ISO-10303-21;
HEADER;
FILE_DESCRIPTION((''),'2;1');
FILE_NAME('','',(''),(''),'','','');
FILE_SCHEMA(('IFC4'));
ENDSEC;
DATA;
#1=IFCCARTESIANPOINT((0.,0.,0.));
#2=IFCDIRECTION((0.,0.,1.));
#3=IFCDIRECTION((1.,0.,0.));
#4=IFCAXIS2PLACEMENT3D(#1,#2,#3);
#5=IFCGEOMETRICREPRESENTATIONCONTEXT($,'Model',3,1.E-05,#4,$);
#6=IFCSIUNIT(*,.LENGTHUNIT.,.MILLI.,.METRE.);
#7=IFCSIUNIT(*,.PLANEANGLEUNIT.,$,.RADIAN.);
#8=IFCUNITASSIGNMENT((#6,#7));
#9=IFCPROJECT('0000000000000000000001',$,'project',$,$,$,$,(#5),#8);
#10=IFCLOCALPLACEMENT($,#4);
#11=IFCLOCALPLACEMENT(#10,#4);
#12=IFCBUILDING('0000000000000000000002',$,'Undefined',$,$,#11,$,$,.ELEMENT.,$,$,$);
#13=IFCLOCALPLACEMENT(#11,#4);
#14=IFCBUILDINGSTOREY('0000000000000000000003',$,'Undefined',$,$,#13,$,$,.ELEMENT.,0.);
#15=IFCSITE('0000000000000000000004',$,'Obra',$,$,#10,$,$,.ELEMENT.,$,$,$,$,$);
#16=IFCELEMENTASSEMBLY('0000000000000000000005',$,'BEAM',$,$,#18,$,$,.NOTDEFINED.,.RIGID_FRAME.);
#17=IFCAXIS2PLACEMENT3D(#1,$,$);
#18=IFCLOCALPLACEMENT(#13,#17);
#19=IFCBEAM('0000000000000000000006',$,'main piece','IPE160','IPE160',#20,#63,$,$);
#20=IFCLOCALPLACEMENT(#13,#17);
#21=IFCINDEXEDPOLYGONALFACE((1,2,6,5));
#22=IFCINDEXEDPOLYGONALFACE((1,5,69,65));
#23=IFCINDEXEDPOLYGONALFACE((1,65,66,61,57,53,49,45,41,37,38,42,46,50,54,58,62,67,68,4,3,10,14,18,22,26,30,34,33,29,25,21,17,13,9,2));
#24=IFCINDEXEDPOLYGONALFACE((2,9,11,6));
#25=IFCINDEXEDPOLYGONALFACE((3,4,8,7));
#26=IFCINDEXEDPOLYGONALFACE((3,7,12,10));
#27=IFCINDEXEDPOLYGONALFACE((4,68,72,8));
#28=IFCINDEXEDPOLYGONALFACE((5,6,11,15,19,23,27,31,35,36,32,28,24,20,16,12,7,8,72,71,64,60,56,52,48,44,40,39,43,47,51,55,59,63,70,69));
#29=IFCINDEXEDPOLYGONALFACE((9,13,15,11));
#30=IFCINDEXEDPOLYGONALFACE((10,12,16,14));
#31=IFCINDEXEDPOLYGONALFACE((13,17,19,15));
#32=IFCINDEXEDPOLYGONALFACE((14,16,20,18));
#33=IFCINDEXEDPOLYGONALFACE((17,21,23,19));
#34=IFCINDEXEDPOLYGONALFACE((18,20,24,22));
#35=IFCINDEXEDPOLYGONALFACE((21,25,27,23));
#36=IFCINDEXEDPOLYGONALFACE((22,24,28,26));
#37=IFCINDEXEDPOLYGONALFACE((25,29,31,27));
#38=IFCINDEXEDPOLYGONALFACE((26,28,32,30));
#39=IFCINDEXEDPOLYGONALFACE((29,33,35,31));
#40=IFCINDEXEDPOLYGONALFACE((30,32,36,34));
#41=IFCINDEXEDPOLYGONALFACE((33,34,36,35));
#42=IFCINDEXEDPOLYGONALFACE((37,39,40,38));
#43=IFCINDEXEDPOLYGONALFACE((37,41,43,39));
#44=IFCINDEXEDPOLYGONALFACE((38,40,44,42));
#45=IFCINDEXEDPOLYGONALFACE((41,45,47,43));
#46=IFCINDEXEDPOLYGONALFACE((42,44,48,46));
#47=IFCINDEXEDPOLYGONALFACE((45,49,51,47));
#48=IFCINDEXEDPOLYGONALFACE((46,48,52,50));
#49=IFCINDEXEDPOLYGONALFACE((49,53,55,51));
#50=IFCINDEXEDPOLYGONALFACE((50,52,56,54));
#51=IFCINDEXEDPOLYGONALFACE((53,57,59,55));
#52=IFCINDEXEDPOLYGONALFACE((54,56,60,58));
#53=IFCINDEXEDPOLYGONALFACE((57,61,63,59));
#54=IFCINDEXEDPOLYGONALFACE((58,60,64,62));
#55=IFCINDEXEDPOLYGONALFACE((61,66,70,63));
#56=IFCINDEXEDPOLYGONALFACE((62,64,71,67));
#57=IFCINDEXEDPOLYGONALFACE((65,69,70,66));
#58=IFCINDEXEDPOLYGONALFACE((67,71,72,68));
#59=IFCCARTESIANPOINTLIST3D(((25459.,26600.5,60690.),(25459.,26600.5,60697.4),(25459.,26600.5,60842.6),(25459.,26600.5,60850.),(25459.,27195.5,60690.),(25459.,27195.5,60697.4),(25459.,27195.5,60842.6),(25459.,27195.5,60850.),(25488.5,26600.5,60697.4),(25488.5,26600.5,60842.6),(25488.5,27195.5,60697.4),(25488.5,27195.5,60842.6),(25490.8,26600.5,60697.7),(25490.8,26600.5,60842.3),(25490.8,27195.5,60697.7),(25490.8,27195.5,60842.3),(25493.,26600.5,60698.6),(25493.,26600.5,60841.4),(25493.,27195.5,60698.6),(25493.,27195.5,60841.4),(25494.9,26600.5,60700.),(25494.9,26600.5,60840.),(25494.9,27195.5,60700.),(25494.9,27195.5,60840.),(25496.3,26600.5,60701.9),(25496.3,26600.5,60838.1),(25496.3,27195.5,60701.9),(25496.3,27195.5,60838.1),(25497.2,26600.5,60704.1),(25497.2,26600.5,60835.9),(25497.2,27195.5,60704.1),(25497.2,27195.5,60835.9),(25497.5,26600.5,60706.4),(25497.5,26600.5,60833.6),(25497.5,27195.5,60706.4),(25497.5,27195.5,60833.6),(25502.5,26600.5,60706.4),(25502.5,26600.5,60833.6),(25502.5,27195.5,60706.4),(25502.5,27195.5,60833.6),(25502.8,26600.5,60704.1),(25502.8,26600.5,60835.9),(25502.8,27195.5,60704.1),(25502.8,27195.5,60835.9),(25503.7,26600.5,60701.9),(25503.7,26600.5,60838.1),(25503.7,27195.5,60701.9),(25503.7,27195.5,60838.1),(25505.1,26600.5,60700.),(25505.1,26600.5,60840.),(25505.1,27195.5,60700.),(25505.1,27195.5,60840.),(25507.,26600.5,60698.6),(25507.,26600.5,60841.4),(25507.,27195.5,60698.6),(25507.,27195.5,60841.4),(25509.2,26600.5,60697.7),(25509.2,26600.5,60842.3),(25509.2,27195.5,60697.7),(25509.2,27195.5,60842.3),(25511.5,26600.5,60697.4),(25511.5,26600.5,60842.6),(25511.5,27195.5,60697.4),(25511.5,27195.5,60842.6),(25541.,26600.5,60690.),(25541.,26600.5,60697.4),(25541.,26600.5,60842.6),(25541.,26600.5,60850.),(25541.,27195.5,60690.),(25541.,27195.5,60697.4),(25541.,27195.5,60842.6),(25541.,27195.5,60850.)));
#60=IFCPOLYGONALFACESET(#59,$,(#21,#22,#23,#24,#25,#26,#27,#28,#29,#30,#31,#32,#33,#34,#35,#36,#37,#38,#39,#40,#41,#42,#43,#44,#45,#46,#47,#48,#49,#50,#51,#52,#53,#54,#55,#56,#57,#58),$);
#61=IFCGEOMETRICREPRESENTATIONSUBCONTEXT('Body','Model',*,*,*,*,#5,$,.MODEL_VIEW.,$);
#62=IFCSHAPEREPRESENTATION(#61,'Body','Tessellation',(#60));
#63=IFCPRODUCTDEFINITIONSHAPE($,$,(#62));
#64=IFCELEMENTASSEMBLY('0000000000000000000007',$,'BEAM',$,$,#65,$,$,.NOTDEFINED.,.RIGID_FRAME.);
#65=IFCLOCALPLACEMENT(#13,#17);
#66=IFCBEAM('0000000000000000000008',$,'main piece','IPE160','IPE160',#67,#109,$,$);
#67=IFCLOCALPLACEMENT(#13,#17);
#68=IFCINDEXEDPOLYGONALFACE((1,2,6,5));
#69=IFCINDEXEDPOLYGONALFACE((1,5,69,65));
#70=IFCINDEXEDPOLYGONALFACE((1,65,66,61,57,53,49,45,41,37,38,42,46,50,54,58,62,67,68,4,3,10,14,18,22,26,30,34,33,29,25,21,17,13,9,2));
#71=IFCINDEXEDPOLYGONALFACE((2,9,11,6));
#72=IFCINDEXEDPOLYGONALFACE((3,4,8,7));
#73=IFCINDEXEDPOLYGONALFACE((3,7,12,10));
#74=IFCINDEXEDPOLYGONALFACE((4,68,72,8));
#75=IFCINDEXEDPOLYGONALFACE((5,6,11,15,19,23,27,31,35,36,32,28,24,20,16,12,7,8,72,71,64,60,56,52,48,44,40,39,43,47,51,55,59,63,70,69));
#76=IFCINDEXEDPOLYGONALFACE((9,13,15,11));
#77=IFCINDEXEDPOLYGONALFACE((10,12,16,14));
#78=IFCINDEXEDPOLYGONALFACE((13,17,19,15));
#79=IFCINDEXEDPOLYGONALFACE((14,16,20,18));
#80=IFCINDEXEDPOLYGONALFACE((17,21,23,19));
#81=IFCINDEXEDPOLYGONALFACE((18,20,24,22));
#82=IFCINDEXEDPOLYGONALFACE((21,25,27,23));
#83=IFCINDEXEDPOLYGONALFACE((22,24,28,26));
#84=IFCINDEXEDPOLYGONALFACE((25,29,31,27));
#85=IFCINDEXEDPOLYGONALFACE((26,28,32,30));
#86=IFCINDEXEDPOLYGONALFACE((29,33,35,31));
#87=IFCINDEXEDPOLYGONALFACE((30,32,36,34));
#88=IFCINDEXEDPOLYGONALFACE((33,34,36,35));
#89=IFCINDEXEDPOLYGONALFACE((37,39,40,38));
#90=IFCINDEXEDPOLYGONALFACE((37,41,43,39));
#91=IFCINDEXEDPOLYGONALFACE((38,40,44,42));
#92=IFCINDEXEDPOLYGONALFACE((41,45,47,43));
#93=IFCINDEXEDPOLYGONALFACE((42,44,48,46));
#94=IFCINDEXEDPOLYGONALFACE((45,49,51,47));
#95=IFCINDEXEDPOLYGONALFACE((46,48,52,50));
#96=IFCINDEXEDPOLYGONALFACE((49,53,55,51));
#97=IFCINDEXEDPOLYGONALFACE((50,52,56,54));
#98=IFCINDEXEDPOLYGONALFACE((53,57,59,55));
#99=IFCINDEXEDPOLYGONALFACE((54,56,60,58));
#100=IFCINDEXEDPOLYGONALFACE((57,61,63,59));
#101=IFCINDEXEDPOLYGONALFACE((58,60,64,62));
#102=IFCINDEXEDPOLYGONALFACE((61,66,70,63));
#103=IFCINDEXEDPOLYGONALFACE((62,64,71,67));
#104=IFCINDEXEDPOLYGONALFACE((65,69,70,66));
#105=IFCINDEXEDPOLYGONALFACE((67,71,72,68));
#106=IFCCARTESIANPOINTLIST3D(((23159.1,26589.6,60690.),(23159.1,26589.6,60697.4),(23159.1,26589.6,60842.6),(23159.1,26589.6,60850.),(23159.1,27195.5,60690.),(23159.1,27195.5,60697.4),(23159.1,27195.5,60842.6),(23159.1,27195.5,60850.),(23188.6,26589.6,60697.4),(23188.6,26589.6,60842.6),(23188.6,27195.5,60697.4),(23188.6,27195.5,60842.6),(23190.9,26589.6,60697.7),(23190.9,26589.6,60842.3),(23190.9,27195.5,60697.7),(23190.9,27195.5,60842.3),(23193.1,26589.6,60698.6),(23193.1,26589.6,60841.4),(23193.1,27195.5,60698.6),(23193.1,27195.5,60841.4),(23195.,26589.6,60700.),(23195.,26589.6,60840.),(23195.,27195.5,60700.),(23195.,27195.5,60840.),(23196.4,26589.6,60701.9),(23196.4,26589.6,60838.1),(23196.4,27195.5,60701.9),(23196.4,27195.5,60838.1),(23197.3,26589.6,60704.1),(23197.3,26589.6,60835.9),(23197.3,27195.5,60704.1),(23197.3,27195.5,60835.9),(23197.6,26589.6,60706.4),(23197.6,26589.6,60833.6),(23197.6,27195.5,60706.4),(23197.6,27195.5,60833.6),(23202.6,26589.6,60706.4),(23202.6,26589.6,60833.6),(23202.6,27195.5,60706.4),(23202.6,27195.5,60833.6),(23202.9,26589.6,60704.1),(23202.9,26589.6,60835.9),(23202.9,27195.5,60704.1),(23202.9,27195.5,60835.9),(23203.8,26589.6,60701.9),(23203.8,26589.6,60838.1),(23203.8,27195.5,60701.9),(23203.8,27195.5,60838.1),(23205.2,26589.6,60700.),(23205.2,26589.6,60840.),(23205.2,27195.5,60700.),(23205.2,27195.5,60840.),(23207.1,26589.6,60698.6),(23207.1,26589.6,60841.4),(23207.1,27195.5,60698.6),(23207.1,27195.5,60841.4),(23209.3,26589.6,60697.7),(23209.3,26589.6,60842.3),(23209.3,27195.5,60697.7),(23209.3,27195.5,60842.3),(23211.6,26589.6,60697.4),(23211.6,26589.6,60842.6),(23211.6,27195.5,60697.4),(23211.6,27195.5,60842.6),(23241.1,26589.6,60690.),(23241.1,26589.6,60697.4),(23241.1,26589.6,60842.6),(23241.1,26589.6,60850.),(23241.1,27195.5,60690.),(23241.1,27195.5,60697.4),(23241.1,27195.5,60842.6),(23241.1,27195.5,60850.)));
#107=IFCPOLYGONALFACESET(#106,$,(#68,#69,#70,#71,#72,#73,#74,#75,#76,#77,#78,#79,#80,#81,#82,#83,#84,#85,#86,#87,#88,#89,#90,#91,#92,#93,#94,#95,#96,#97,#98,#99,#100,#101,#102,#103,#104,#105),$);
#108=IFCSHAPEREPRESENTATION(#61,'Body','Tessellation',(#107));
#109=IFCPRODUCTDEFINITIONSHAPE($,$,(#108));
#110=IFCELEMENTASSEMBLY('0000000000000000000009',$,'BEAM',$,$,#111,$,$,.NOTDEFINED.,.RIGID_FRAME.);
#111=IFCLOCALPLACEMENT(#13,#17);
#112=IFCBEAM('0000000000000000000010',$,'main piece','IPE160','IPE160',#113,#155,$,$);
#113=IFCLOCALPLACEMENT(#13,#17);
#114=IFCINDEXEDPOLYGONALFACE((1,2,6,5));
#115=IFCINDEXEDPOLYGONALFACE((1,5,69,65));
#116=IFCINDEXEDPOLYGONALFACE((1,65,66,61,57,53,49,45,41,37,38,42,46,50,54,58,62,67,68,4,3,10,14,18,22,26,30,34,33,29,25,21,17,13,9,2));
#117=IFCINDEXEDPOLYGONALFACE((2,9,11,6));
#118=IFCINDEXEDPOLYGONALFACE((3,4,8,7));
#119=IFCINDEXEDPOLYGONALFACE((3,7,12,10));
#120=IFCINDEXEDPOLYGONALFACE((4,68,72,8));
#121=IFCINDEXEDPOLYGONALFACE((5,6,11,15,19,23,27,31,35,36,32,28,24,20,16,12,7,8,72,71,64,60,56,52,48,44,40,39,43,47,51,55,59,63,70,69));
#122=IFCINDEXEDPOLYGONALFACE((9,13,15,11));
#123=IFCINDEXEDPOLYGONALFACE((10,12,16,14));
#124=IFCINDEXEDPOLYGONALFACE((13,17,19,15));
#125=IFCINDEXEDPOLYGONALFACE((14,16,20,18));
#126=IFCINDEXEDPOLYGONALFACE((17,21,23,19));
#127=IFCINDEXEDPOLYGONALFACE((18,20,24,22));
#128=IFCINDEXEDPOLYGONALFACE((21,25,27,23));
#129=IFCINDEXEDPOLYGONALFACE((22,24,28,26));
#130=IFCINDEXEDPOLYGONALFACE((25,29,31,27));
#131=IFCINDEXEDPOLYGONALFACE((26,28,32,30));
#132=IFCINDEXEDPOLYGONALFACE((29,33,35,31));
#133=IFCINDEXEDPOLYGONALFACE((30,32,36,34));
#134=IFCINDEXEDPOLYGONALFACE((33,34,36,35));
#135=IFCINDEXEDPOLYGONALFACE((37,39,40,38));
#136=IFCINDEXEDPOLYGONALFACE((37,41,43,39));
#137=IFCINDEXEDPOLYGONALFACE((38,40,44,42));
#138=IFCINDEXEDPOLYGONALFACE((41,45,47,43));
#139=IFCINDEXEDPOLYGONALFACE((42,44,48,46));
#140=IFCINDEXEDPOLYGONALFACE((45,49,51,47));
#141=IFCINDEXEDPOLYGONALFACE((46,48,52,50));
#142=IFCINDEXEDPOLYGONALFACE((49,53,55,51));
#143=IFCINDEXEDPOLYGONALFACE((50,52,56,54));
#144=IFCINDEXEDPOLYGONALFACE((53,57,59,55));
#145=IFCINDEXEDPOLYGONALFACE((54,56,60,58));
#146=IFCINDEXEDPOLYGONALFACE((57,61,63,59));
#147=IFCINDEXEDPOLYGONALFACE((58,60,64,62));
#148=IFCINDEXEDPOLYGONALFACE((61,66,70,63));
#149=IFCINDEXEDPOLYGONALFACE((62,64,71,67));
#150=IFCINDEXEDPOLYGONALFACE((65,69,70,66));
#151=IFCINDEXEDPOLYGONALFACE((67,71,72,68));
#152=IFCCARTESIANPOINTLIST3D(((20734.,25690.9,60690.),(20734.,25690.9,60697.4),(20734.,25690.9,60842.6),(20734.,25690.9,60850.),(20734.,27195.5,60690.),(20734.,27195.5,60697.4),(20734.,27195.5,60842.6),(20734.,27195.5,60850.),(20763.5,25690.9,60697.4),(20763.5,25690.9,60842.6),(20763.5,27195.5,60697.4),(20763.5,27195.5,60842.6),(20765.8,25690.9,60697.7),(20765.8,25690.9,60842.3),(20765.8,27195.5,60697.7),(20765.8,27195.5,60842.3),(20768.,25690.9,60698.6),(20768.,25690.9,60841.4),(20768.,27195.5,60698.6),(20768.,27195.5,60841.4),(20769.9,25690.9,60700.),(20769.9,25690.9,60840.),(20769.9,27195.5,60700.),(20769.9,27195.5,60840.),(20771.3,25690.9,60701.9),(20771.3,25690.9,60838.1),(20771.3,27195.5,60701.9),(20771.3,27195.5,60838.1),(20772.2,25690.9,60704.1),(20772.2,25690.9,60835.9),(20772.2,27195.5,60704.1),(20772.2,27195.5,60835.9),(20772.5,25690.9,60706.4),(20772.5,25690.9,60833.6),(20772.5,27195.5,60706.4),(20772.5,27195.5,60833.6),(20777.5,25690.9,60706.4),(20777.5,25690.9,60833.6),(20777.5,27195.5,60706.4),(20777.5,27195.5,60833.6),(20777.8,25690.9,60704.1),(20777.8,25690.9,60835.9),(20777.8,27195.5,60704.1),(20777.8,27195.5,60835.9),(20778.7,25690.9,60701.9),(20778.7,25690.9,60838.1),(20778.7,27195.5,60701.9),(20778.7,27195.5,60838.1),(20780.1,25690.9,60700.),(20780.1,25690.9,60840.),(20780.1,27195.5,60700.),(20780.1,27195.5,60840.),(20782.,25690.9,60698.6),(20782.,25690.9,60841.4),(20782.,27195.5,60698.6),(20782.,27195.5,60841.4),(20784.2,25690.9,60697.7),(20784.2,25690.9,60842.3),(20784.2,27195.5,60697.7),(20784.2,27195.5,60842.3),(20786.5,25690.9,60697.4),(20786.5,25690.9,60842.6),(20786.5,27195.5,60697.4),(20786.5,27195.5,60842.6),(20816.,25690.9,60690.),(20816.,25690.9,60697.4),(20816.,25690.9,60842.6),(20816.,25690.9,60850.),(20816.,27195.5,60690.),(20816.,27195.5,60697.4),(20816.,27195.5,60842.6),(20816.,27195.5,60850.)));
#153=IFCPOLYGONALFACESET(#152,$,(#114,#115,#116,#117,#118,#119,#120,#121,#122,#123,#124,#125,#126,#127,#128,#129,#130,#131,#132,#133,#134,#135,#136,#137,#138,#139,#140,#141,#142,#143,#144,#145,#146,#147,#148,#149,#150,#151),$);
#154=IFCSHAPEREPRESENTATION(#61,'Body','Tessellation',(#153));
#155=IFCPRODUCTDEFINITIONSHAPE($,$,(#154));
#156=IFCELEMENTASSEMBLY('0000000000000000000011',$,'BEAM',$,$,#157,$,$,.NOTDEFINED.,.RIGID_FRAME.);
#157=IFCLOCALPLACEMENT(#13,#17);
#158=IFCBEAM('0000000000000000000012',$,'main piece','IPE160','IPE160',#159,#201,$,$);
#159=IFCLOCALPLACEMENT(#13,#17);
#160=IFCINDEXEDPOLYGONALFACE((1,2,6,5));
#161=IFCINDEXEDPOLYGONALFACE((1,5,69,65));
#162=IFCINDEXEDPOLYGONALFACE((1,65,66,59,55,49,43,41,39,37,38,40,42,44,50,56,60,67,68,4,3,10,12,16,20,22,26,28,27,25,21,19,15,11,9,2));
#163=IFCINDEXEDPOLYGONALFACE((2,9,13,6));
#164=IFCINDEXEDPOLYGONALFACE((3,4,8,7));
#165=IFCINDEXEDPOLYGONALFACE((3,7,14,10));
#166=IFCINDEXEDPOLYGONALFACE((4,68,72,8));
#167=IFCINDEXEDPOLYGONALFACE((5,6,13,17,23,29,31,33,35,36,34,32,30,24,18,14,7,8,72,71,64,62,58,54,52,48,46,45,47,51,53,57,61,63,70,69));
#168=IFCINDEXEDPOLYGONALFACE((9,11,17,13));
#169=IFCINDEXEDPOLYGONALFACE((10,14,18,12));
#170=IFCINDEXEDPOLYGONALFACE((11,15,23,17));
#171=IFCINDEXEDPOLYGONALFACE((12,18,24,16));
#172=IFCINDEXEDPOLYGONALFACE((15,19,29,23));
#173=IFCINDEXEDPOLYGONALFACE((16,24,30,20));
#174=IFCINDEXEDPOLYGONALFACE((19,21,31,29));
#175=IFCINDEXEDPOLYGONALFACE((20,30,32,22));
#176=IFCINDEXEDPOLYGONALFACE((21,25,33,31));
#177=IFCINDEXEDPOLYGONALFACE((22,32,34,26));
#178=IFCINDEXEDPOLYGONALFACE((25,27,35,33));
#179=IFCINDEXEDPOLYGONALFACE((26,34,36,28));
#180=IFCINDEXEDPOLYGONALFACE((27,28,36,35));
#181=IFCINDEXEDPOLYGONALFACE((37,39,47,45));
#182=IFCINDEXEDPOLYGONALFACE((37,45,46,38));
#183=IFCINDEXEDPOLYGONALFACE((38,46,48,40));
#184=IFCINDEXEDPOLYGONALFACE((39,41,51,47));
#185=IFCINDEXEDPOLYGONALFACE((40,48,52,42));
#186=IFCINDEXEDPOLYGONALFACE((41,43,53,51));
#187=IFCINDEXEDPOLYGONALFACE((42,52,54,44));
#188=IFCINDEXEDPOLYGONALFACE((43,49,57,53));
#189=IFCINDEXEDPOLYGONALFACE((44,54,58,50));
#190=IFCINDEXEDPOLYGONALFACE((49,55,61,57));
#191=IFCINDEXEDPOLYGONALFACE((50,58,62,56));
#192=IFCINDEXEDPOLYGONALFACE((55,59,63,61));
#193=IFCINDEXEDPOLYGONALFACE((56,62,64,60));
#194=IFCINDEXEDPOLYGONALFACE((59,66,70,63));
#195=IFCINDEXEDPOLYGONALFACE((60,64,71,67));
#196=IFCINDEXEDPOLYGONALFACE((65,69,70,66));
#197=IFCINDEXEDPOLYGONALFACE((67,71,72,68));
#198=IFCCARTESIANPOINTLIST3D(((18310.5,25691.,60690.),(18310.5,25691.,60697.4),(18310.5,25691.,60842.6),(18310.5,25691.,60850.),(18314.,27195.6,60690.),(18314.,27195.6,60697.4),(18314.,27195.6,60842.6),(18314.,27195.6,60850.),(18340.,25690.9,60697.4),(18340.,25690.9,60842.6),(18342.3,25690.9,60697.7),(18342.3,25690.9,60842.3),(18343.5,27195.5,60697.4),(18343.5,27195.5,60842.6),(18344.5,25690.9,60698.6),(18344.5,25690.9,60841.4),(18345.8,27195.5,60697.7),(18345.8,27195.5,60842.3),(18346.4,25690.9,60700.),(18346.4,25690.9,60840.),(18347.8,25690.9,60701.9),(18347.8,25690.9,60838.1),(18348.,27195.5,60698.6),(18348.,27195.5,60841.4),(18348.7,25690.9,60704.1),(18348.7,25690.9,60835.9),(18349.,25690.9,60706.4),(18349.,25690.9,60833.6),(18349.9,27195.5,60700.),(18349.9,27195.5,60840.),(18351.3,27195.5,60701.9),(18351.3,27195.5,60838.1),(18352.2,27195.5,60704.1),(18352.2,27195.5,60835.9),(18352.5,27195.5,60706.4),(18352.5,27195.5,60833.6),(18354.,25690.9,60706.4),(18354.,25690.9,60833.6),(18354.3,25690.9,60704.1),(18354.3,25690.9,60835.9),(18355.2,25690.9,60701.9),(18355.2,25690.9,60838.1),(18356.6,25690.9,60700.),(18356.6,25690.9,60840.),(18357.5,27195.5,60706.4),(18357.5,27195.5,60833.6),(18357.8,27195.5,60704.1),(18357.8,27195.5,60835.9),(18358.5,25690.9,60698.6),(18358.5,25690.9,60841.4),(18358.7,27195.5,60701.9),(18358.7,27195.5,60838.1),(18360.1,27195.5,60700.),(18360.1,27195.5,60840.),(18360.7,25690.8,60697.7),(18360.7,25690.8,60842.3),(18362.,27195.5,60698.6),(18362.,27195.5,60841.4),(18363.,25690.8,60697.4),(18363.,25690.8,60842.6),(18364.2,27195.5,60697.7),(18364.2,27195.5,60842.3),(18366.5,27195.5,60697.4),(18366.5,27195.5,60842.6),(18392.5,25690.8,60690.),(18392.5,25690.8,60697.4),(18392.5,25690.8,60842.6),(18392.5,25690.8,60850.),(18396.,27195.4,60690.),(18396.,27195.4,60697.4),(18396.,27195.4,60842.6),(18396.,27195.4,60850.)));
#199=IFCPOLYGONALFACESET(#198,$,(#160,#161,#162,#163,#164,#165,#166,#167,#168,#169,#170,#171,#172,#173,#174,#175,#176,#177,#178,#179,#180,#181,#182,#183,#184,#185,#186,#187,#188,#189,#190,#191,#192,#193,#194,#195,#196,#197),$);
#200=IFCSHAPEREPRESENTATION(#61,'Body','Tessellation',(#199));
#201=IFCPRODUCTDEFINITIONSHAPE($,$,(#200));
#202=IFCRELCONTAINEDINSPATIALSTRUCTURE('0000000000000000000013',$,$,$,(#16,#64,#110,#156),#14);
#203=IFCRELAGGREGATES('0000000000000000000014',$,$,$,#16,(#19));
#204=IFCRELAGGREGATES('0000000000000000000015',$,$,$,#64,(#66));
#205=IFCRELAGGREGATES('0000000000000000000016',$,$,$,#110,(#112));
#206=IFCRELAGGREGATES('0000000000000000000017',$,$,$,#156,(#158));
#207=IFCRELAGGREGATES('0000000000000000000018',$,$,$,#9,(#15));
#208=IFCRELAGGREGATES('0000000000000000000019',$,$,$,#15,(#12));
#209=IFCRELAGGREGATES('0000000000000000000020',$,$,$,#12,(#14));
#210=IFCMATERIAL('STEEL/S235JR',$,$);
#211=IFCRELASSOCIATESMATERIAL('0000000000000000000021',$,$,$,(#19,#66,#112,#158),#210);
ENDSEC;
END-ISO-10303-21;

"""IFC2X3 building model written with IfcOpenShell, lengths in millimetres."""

from ifc_helpers import new_model, si_unit, frame, origin_with_axes, origin_2d_with_axis, place, context, subcontext, project, spatial, i_section, extrude, material, element, aggregate, save


model = new_model("IFC2X3")

# Units and contexts
model_context = context("Model", 3, precision=1e-05, world=origin_with_axes())
body_context = subcontext(model_context, "Body", "Model", "MODEL_VIEW")
ifc_project = project(units=[si_unit("LENGTHUNIT", "METRE", prefix="MILLI"), si_unit("PLANEANGLEUNIT", "RADIAN")], contexts=[model_context])

# Site, building, storey
site_placement = place(None, origin_with_axes())
site = spatial("IfcSite", under=ifc_project, at=site_placement, Name="Obra", CompositionType="ELEMENT")
building_placement = place(site_placement, origin_with_axes())
building = spatial("IfcBuilding", under=site, at=building_placement, Name="Undefined", CompositionType="ELEMENT")
storey_placement = place(building_placement, origin_with_axes())
storey = spatial("IfcBuildingStorey", under=building, at=storey_placement, Name="Undefined", CompositionType="ELEMENT", Elevation=0.0)

# Element assemblies, beams
ifc_material_1 = material(Name="STEEL/S235JR")
assembly_1_placement = place(storey_placement, origin_with_axes())
assembly_1 = element("IfcElementAssembly", 1, at=assembly_1_placement, inside=storey, Name="BEAM", AssemblyPlace="NOTDEFINED", PredefinedType="RIGID_FRAME")
beam_1_placement = place(assembly_1_placement, frame((25500.0, 26600.5, 60770.0), z_axis=(0.0, 0.0, 1.0), x_axis=(0.0, 1.0, 0.0)))
beam_1 = element("IfcBeam", 2, at=beam_1_placement, material=ifc_material_1, Name="main piece", Description="IPE160", ObjectType="IPE160", context=body_context, shape_type="SweptSolid", body=[
    extrude(i_section(OverallWidth=82.0, OverallDepth=160.0, WebThickness=5.0, FlangeThickness=7.4, FilletRadius=9.0, at=origin_2d_with_axis()), frame((595.0, 0.0, 0.0), z_axis=(-1.0, 0.0, 0.0), x_axis=(0.0, -1.0, 0.0)), (0.0, 0.0, 1.0), 595.0),
])
aggregate(assembly_1, [beam_1])
assembly_2_placement = place(storey_placement, origin_with_axes())
assembly_2 = element("IfcElementAssembly", 3, at=assembly_2_placement, inside=storey, Name="BEAM", AssemblyPlace="NOTDEFINED", PredefinedType="RIGID_FRAME")
beam_2_placement = place(assembly_2_placement, frame((23200.1, 26589.6, 60770.0), z_axis=(0.0, 0.0, 1.0), x_axis=(0.0, 1.0, 0.0)))
beam_2 = element("IfcBeam", 4, at=beam_2_placement, material=ifc_material_1, Name="main piece", Description="IPE160", ObjectType="IPE160", context=body_context, shape_type="SweptSolid", body=[
    extrude(i_section(OverallWidth=82.0, OverallDepth=160.0, WebThickness=5.0, FlangeThickness=7.4, FilletRadius=9.0, at=origin_2d_with_axis()), frame((605.9, 0.0, 0.0), z_axis=(-1.0, 0.0, 0.0), x_axis=(0.0, -1.0, 0.0)), (0.0, 0.0, 1.0), 605.9),
])
aggregate(assembly_2, [beam_2])
assembly_3_placement = place(storey_placement, origin_with_axes())
assembly_3 = element("IfcElementAssembly", 5, at=assembly_3_placement, inside=storey, Name="BEAM", AssemblyPlace="NOTDEFINED", PredefinedType="RIGID_FRAME")
beam_3_placement = place(assembly_3_placement, frame((20775.0, 25690.9, 60770.0), z_axis=(0.0, 0.0, 1.0), x_axis=(0.0, 1.0, 0.0)))
beam_3 = element("IfcBeam", 6, at=beam_3_placement, material=ifc_material_1, Name="main piece", Description="IPE160", ObjectType="IPE160", context=body_context, shape_type="SweptSolid", body=[
    extrude(i_section(OverallWidth=82.0, OverallDepth=160.0, WebThickness=5.0, FlangeThickness=7.4, FilletRadius=9.0, at=origin_2d_with_axis()), frame((1504.6, 0.0, 0.0), z_axis=(-1.0, 0.0, 0.0), x_axis=(0.0, -1.0, 0.0)), (0.0, 0.0, 1.0), 1504.6),
])
aggregate(assembly_3, [beam_3])
assembly_4_placement = place(storey_placement, origin_with_axes())
assembly_4 = element("IfcElementAssembly", 7, at=assembly_4_placement, inside=storey, Name="BEAM", AssemblyPlace="NOTDEFINED", PredefinedType="RIGID_FRAME")
beam_4_placement = place(assembly_4_placement, frame((18351.5, 25690.9, 60770.0), z_axis=(0.0, 0.0, 1.0), x_axis=(0.002325, 0.999997, 0.0)))
beam_4 = element("IfcBeam", 8, at=beam_4_placement, material=ifc_material_1, Name="main piece", Description="IPE160", ObjectType="IPE160", context=body_context, shape_type="SweptSolid", body=[
    extrude(i_section(OverallWidth=82.0, OverallDepth=160.0, WebThickness=5.0, FlangeThickness=7.4, FilletRadius=9.0, at=origin_2d_with_axis()), frame((1504.6, 0.0, 0.0), z_axis=(-1.0, 0.0, 0.0), x_axis=(0.0, -1.0, 0.0)), (0.0, 0.0, 1.0), 1504.6),
])
aggregate(assembly_4, [beam_4])

save(model, "model.ifc")
